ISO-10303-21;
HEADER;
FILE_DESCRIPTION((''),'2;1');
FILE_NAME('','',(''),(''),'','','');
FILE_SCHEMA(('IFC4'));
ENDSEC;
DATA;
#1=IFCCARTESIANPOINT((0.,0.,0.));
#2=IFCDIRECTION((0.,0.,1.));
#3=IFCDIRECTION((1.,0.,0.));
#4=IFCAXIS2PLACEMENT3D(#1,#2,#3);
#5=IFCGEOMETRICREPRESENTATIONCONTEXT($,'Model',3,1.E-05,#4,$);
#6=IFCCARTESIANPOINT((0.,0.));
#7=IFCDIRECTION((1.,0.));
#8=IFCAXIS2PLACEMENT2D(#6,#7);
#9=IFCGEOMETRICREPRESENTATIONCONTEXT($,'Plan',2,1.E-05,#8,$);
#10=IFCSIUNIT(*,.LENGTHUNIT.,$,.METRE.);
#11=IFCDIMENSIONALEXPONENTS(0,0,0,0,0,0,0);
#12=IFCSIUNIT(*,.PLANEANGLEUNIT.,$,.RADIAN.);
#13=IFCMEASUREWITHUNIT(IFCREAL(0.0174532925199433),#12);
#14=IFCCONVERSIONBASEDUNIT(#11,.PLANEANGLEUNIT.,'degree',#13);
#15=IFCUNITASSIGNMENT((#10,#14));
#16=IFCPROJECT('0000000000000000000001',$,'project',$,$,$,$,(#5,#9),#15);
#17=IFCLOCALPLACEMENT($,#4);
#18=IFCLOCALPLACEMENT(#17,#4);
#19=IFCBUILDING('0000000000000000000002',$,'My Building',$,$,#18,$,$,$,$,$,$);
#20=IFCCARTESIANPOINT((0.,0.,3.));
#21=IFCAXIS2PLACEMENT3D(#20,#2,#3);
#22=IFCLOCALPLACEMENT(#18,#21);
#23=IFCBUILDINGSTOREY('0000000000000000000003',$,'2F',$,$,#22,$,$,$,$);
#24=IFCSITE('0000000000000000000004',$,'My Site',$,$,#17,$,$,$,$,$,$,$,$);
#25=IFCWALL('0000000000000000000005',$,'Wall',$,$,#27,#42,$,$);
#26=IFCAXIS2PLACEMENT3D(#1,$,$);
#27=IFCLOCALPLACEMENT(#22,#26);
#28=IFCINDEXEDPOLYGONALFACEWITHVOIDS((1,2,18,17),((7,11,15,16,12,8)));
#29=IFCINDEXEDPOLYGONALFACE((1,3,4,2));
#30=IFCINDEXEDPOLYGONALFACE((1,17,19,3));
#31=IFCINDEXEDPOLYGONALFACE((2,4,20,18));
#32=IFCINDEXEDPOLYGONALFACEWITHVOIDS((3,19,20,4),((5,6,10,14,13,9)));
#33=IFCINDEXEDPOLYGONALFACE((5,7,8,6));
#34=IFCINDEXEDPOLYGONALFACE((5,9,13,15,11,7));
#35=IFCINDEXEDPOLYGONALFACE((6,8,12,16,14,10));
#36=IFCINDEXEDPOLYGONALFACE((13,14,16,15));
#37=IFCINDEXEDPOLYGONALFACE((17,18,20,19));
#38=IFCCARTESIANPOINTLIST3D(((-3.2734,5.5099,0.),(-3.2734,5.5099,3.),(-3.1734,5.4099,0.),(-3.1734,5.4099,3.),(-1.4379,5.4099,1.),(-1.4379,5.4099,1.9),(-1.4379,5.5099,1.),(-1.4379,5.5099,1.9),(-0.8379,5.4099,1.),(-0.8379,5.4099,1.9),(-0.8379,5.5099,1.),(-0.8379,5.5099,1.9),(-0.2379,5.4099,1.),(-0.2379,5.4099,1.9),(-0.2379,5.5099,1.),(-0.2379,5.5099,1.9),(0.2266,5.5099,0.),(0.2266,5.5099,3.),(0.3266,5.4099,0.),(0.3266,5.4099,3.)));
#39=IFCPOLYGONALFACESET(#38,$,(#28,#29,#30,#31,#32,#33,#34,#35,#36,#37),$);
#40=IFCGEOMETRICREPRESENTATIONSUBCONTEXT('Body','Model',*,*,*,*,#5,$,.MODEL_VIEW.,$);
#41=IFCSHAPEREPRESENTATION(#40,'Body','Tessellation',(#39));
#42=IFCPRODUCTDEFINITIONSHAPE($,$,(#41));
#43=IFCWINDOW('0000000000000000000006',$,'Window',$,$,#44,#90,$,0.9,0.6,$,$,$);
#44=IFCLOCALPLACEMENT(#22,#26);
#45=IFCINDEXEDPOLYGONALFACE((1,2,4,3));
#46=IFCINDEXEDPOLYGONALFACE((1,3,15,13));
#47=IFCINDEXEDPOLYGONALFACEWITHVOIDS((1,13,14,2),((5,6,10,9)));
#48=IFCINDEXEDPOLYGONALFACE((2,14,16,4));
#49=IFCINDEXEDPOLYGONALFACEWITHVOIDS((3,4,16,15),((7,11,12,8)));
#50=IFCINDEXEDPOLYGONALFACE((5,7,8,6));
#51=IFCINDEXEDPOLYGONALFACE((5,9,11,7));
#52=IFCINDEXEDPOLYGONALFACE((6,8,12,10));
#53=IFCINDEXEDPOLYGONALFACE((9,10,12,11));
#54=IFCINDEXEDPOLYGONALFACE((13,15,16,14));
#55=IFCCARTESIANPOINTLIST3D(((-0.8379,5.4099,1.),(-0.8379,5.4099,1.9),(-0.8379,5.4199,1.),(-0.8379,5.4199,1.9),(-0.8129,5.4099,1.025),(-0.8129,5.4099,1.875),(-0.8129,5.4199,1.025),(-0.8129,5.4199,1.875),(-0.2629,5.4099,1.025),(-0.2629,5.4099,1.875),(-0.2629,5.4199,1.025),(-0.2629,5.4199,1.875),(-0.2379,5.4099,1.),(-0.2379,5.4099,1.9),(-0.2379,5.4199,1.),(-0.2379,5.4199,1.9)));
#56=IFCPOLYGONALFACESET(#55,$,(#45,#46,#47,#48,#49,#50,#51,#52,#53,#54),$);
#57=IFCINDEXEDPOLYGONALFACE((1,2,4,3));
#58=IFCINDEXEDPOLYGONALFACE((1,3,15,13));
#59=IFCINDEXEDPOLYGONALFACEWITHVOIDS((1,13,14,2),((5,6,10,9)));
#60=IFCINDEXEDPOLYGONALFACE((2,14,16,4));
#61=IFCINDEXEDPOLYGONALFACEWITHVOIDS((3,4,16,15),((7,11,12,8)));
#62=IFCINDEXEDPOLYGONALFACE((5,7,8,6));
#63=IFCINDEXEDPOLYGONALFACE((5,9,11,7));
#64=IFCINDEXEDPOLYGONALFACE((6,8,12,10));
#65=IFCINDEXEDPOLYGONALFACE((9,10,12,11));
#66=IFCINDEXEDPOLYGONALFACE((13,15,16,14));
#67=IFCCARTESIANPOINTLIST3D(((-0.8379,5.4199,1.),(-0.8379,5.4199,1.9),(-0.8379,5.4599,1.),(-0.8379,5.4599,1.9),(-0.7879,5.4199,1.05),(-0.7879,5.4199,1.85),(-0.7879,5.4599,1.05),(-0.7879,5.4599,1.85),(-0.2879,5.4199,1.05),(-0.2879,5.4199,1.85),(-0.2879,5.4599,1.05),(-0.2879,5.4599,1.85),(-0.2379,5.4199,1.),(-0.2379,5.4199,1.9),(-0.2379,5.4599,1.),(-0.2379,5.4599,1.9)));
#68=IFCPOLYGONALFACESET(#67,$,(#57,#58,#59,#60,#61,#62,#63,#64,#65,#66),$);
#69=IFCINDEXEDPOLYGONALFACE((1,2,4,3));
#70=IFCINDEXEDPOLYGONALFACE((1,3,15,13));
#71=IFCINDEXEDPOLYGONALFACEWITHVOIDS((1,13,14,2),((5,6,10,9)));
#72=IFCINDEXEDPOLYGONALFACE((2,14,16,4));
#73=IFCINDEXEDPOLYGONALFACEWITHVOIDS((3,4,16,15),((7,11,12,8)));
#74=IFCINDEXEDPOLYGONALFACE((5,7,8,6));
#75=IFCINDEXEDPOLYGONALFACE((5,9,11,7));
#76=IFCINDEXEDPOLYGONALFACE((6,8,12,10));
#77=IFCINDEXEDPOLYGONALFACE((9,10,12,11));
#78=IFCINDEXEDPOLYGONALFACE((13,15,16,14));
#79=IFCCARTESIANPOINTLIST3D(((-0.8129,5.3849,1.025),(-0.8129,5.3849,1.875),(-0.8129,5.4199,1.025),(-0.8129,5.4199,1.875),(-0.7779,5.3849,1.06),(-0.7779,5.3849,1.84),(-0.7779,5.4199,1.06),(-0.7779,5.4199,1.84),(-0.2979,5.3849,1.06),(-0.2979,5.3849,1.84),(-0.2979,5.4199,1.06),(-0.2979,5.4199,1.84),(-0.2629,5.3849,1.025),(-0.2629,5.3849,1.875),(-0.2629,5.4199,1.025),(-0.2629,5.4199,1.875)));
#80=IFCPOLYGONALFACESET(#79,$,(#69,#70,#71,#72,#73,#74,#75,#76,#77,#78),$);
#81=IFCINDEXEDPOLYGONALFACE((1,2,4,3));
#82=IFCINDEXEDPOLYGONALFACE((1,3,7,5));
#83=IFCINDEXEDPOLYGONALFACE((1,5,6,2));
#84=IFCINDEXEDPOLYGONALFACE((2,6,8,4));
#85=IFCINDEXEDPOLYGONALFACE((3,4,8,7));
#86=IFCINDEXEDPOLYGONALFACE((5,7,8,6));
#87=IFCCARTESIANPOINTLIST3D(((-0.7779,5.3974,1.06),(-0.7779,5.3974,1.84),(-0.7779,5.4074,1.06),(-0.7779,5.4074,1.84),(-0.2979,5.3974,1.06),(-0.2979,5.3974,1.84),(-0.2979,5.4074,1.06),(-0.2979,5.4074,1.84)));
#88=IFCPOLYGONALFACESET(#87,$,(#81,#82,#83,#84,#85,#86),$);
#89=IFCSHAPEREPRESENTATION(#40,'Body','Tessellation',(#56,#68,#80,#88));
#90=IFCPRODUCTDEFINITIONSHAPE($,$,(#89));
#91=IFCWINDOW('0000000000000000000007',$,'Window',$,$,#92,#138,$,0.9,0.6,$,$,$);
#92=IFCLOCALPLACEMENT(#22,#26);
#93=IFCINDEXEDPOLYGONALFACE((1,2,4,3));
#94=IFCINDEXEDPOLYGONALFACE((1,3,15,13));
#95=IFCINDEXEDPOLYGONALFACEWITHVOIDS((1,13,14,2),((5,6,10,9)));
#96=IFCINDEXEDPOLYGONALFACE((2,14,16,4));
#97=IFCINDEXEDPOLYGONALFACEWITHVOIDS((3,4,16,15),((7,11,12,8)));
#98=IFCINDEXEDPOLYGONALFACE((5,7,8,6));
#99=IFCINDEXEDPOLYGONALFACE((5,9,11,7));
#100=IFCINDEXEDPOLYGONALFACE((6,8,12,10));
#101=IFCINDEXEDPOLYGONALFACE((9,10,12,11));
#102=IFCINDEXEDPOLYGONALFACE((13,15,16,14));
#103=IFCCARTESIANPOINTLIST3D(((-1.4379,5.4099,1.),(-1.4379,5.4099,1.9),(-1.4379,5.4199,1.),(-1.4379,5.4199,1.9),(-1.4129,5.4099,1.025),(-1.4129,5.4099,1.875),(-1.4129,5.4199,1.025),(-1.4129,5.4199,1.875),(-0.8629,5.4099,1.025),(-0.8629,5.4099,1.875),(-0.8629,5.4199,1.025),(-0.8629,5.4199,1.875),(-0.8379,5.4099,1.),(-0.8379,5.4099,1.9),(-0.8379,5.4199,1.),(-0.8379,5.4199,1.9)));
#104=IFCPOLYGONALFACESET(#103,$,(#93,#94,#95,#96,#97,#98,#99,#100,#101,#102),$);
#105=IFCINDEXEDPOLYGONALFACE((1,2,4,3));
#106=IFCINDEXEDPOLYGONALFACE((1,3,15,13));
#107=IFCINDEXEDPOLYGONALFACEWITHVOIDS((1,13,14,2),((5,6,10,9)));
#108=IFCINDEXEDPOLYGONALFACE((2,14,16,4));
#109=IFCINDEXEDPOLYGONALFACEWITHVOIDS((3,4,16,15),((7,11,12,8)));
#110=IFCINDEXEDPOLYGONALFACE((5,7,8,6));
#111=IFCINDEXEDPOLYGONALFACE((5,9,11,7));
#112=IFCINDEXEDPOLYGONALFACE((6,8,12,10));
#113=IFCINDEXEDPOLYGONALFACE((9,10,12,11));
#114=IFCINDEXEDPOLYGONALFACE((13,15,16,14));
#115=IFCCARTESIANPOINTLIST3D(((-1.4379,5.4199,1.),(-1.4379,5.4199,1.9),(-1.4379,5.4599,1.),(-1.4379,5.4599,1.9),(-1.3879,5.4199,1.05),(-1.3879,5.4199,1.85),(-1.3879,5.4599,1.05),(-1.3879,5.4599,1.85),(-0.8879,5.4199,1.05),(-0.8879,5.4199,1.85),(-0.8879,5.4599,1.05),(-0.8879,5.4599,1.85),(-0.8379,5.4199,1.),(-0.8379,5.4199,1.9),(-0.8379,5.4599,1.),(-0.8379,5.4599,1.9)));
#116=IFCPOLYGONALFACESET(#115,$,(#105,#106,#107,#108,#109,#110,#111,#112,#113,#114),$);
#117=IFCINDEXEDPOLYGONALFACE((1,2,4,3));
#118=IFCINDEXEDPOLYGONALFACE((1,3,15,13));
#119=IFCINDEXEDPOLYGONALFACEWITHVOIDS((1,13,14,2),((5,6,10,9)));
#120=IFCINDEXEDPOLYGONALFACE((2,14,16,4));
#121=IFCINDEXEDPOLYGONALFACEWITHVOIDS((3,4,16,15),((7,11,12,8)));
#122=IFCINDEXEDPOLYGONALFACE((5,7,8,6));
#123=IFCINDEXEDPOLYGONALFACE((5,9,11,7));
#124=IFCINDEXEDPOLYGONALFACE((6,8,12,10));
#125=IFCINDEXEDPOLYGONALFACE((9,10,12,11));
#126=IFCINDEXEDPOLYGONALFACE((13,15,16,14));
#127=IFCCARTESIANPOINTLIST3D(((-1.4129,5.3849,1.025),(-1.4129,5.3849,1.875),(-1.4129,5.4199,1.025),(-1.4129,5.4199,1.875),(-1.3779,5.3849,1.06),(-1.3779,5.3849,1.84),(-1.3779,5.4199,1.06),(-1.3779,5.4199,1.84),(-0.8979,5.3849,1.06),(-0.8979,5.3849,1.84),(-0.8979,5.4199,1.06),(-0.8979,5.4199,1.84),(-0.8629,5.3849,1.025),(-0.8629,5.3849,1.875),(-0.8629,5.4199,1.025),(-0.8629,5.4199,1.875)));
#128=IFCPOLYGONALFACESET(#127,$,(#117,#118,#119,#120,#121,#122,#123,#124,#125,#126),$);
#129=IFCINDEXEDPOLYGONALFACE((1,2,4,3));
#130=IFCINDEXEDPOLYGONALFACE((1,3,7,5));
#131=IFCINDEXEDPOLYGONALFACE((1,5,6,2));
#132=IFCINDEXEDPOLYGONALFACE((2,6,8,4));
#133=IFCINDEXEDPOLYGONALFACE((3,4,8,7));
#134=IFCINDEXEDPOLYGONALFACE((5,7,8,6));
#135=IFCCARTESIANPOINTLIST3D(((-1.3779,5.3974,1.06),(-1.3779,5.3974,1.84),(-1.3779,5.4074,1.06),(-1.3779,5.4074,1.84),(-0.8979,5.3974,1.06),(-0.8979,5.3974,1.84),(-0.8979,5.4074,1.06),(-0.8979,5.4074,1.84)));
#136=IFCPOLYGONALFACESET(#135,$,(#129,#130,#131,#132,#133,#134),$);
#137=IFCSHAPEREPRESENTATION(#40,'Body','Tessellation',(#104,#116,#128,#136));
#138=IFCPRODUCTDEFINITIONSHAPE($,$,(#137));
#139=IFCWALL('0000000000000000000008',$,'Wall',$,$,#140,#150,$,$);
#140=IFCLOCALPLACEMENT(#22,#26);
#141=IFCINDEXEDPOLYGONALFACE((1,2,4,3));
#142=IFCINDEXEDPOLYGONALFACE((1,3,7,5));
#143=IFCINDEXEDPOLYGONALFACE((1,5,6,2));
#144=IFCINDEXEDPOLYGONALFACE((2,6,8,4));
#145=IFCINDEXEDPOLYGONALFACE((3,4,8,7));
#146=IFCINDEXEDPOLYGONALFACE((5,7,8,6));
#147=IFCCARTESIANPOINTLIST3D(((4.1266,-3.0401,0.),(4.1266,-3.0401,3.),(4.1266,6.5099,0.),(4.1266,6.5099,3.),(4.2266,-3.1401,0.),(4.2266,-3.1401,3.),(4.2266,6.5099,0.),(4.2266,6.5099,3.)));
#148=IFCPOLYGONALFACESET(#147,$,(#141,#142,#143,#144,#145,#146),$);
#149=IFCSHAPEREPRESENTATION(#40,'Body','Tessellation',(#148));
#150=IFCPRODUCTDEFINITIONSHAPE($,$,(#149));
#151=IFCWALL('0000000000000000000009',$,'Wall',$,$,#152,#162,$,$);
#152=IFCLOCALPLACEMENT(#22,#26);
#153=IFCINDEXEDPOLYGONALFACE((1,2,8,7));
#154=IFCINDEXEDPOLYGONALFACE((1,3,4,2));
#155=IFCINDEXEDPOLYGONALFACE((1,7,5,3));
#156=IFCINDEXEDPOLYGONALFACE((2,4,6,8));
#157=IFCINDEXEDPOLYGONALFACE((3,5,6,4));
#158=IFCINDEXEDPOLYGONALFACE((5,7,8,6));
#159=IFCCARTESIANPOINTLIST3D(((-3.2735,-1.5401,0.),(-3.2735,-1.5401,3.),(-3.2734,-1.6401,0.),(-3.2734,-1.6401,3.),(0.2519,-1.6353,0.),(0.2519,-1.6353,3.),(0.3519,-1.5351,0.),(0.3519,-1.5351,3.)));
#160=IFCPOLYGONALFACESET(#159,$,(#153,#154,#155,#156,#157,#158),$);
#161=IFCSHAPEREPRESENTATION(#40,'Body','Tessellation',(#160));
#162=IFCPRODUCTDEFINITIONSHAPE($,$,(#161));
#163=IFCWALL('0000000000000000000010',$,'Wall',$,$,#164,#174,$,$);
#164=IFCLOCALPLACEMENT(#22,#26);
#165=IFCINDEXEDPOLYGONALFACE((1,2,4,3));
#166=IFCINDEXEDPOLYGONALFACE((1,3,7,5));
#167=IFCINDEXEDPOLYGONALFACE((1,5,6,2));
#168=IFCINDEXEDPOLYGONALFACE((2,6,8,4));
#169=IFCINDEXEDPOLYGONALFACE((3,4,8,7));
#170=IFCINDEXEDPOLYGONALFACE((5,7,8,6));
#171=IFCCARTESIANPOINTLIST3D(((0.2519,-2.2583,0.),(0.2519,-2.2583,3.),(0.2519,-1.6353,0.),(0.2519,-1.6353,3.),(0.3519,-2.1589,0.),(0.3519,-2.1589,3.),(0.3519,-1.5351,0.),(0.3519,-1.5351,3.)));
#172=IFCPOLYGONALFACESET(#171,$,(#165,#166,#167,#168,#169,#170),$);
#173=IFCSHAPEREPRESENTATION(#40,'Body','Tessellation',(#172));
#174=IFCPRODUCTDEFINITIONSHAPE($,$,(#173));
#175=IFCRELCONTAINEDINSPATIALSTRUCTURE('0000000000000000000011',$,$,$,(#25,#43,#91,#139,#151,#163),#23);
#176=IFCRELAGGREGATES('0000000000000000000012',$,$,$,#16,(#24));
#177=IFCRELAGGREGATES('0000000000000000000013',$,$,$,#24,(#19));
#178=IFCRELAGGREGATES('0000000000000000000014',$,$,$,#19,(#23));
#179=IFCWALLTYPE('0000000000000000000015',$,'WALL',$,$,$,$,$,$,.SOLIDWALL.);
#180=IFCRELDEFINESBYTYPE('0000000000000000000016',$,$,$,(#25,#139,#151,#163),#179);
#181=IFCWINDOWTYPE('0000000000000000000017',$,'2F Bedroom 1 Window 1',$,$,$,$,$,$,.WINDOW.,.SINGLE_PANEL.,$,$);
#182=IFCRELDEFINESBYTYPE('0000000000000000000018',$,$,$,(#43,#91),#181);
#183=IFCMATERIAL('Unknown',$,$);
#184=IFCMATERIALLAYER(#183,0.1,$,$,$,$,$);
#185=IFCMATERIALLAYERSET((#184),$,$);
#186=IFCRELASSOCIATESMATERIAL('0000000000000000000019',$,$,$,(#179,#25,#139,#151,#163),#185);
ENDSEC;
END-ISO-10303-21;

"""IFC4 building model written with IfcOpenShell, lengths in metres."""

from ifc_helpers import new_model, entity, si_unit, converted_unit, frame, origin_with_axes, origin_2d_with_axis, place, context, subcontext, project, spatial, line, indexed_curve, outline, extrude, shape, source, transform, mapped, material, layer, layer_set, layer_usage, type_object, type_shapes, element, fill, save


model = new_model("IFC4")

# Units and contexts
model_context = context("Model", 3, precision=1e-05, world=origin_with_axes())
plan_context = context("Plan", 2, precision=1e-05, world=origin_2d_with_axis())
body_context_1 = subcontext(model_context, "Body", "Model", "MODEL_VIEW")
body_context_2 = subcontext(plan_context, "Body", "Plan", "PLAN_VIEW")
ifc_project = project(units=[si_unit("LENGTHUNIT", "METRE"), converted_unit("PLANEANGLEUNIT", "degree", entity("IfcReal", 0.0174532925199433), si_unit("PLANEANGLEUNIT", "RADIAN"), dimensions=[0, 0, 0, 0, 0, 0, 0])], contexts=[model_context, plan_context])

# Site, building, storey
site_placement = place(None, origin_with_axes())
site = spatial("IfcSite", under=ifc_project, at=site_placement, Name="My Site")
building_placement = place(site_placement, origin_with_axes())
building = spatial("IfcBuilding", under=site, at=building_placement, Name="My Building")
storey_placement = place(building_placement, frame((0.0, 0.0, 3.0), z_axis=(0.0, 0.0, 1.0), x_axis=(1.0, 0.0, 0.0)))
storey = spatial("IfcBuildingStorey", under=building, at=storey_placement, Name="2F")

# Shared definitions
ifc_material = material(Name="Unknown")

# Shared definitions
ifc_layer_1 = layer(ifc_material, 0.1)
ifc_layer_set_1 = layer_set([ifc_layer_1])
wall_type = type_object("IfcWallType", Name="WALL", PredefinedType="SOLIDWALL", material=ifc_layer_set_1)

# Wall, openings, windows
ifc_layer_usage_1 = layer_usage(ifc_layer_set_1, "AXIS2", "POSITIVE", 0.0)
wall_1_placement = place(storey_placement, frame((0.2266, 5.5099, 0.0), z_axis=(0.0, 0.0, 1.0), x_axis=(-1.0, 0.0, 0.0)))
wall_1 = element("IfcWall", 1, at=wall_1_placement, inside=storey, type_object=wall_type, material=ifc_layer_usage_1, Name="Wall", context=body_context_1, shape_type="SweptSolid", body=[
    extrude(outline(indexed_curve([(0.0, 0.0), (-0.1, 0.1), (3.4, 0.1), (3.5, 0.0)], segments=[line(1, 2, 3, 4, 1)])), origin_with_axes(), (0.0, 0.0, 1.0), 3.0),
])
shared_shape_1 = source(origin_with_axes(), body_context_1, "Body", "SweptSolid", [
    extrude(outline(indexed_curve([(0.0, 0.0), (0.6, 0.0), (0.6, 0.9), (0.0, 0.9)], segments=[line(1, 2, 3, 4, 1)])), frame((0.0, -0.6, 0.0), z_axis=(0.0, -1.0, 0.0), x_axis=(1.0, 0.0, 0.0)), (0.0, 0.0, -1.0), 1.2),
])
opening_1_placement = place(wall_1_placement, frame((0.4645, 0.0, 1.0), z_axis=(0.0, 0.0, 1.0), x_axis=(1.0, 0.0, 0.0)))
opening_1 = element("IfcOpeningElement", 2, at=opening_1_placement, cuts=wall_1, PredefinedType="OPENING", context=body_context_1, shape_type="MappedRepresentation", body=[
    mapped(shared_shape_1, transform((0.0, 0.0, 0.0), x_axis=(1.0, 0.0, 0.0), y_axis=(0.0, 1.0, 0.0), z_axis=(0.0, 0.0, 1.0), scale=1.0)),
])
opening_2_placement = place(wall_1_placement, frame((1.0645, 0.0, 1.0), z_axis=(0.0, 0.0, 1.0), x_axis=(1.0, 0.0, 0.0)))
opening_2 = element("IfcOpeningElement", 3, at=opening_2_placement, cuts=wall_1, PredefinedType="OPENING", context=body_context_1, shape_type="MappedRepresentation", body=[
    mapped(shared_shape_1, transform((0.0, 0.0, 0.0), x_axis=(1.0, 0.0, 0.0), y_axis=(0.0, 1.0, 0.0), z_axis=(0.0, 0.0, 1.0), scale=1.0)),
])
window_type_1 = type_object("IfcWindowType", Name="2F Bedroom 1 Window 1", PartitioningType="SINGLE_PANEL", PredefinedType="WINDOW")
shared_shape_2 = source(origin_with_axes(), body_context_1, "Body", "SweptSolid", [
    extrude(outline(indexed_curve([(0.0, 0.0), (0.6, 0.0), (0.6, 0.9), (0.0, 0.9)], segments=[line(1, 2, 3, 4, 1)]), holes=[indexed_curve([(0.025, 0.025), (0.575, 0.025), (0.575, 0.875), (0.025, 0.875)], segments=[line(1, 2, 3, 4, 1)])]), frame((0.0, 0.09, 0.0), z_axis=(0.0, -1.0, 0.0), x_axis=(1.0, 0.0, 0.0)), (0.0, 0.0, -1.0), 0.01),
    extrude(outline(indexed_curve([(0.0, 0.0), (0.6, 0.0), (0.6, 0.9), (0.0, 0.9)], segments=[line(1, 2, 3, 4, 1)]), holes=[indexed_curve([(0.05, 0.05), (0.55, 0.05), (0.55, 0.85), (0.05, 0.85)], segments=[line(1, 2, 3, 4, 1)])]), frame((0.0, 0.05, 0.0), z_axis=(0.0, -1.0, 0.0), x_axis=(1.0, 0.0, 0.0)), (0.0, 0.0, -1.0), 0.04),
    extrude(outline(indexed_curve([(0.0, 0.0), (0.55, 0.0), (0.55, 0.85), (0.0, 0.85)], segments=[line(1, 2, 3, 4, 1)]), holes=[indexed_curve([(0.035, 0.035), (0.515, 0.035), (0.515, 0.815), (0.035, 0.815)], segments=[line(1, 2, 3, 4, 1)])]), frame((0.025, 0.09, 0.025), z_axis=(0.0, -1.0, 0.0), x_axis=(1.0, 0.0, 0.0)), (0.0, 0.0, -1.0), 0.035),
    extrude(outline(indexed_curve([(0.035, 0.035), (0.515, 0.035), (0.515, 0.815), (0.035, 0.815)], segments=[line(1, 2, 3, 4, 1)])), frame((0.025, 0.1025, 0.025), z_axis=(0.0, -1.0, 0.0), x_axis=(1.0, 0.0, 0.0)), (0.0, 0.0, -1.0), 0.01),
])
shared_shape_3 = source(origin_with_axes(), body_context_2, "Body", "Curve2D", [
    entity("IfcIndexedPolyCurve", entity("IfcCartesianPointList2D", [[0.05, 0.05], [0.55, 0.05]])),
    entity("IfcIndexedPolyCurve", entity("IfcCartesianPointList2D", [[0.0, 0.1], [0.025, 0.1], [0.025, 0.09], [0.05, 0.09], [0.05, 0.05], [0.0, 0.05]]), [entity("IfcLineIndex", [1, 2, 3, 4, 5, 6, 1])]),
    entity("IfcIndexedPolyCurve", entity("IfcCartesianPointList2D", [[0.6, 0.1], [0.575, 0.1], [0.575, 0.09], [0.55, 0.09], [0.55, 0.05], [0.6, 0.05]]), [entity("IfcLineIndex", [1, 2, 3, 4, 5, 6, 1])]),
    entity("IfcIndexedPolyCurve", entity("IfcCartesianPointList2D", [[0.025, 0.09], [0.06, 0.09], [0.06, 0.125], [0.025, 0.125]]), [entity("IfcLineIndex", [1, 2, 3, 4, 1])]),
    entity("IfcIndexedPolyCurve", entity("IfcCartesianPointList2D", [[0.575, 0.09], [0.54, 0.09], [0.54, 0.125], [0.575, 0.125]]), [entity("IfcLineIndex", [1, 2, 3, 4, 1])]),
    entity("IfcIndexedPolyCurve", entity("IfcCartesianPointList2D", [[0.06, 0.09], [0.54, 0.09]])),
    entity("IfcIndexedPolyCurve", entity("IfcCartesianPointList2D", [[0.06, 0.125], [0.54, 0.125]])),
    entity("IfcIndexedPolyCurve", entity("IfcCartesianPointList2D", [[0.06, 0.1075], [0.54, 0.1075]])),
])
type_shapes(window_type_1, [shared_shape_2, shared_shape_3])
window_1_placement = place(opening_1_placement, frame((0.0, 0.0, 0.0), z_axis=(0.0, 0.0, 1.0), x_axis=(1.0, 0.0, 0.0)))
window_1 = element("IfcWindow", 4, at=window_1_placement, inside=storey, type_object=window_type_1, Name="Window", OverallHeight=0.9, OverallWidth=0.6, shapes=[
    shape(body_context_1, "Body", "MappedRepresentation", [mapped(shared_shape_2, transform((0.0, 0.0, 0.0), x_axis=(1.0, 0.0, 0.0), y_axis=(0.0, 1.0, 0.0), z_axis=(0.0, 0.0, 1.0), scale=1.0))]),
    shape(body_context_2, "Body", "MappedRepresentation", [mapped(shared_shape_3, transform((0.0, 0.0, 0.0), x_axis=(1.0, 0.0, 0.0), y_axis=(0.0, 1.0, 0.0), z_axis=(0.0, 0.0, 1.0), scale=1.0))]),
])
fill(opening_1, window_1)
window_2_placement = place(opening_2_placement, frame((0.0, 0.0, 0.0), z_axis=(0.0, 0.0, 1.0), x_axis=(1.0, 0.0, 0.0)))
window_2 = element("IfcWindow", 5, at=window_2_placement, inside=storey, type_object=window_type_1, Name="Window", OverallHeight=0.9, OverallWidth=0.6, shapes=[
    shape(body_context_1, "Body", "MappedRepresentation", [mapped(shared_shape_2, transform((0.0, 0.0, 0.0), x_axis=(1.0, 0.0, 0.0), y_axis=(0.0, 1.0, 0.0), z_axis=(0.0, 0.0, 1.0), scale=1.0))]),
    shape(body_context_2, "Body", "MappedRepresentation", [mapped(shared_shape_3, transform((0.0, 0.0, 0.0), x_axis=(1.0, 0.0, 0.0), y_axis=(0.0, 1.0, 0.0), z_axis=(0.0, 0.0, 1.0), scale=1.0))]),
])
fill(opening_2, window_2)

# Walls
ifc_layer_usage_2 = layer_usage(ifc_layer_set_1, "AXIS2", "POSITIVE", 0.0)
wall_2_placement = place(storey_placement, frame((4.2266, -3.1401, 0.0), z_axis=(0.0, 0.0, 1.0), x_axis=(0.0, 1.0, 0.0)))
element("IfcWall", 6, at=wall_2_placement, inside=storey, type_object=wall_type, material=ifc_layer_usage_2, Name="Wall", context=body_context_1, shape_type="SweptSolid", body=[
    extrude(outline(indexed_curve([(0.0, 0.0), (0.1, 0.1), (9.65, 0.1), (9.65, 0.0)], segments=[line(1, 2, 3, 4, 1)])), origin_with_axes(), (0.0, 0.0, 1.0), 3.0),
])
ifc_layer_usage_3 = layer_usage(ifc_layer_set_1, "AXIS2", "POSITIVE", 0.0)
wall_3_placement = place(storey_placement, frame((-3.2734, -1.6401, 0.0), z_axis=(0.0, 0.0, 1.0), x_axis=(0.999999, 0.001371, 0.0)))
element("IfcWall", 7, at=wall_3_placement, inside=storey, type_object=wall_type, material=ifc_layer_usage_3, Name="Wall", context=body_context_1, shape_type="SweptSolid", body=[
    extrude(outline(indexed_curve([(0.0, 0.0), (0.0, 0.1), (3.6254, 0.1), (3.5253, 0.0)], segments=[line(1, 2, 3, 4, 1)])), origin_with_axes(), (0.0, 0.0, 1.0), 3.0),
])
ifc_layer_usage_4 = layer_usage(ifc_layer_set_1, "AXIS2", "POSITIVE", 0.0)
wall_4_placement = place(storey_placement, frame((0.2519, -1.6353, 0.0), z_axis=(0.0, 0.0, 1.0), x_axis=(0.0, -1.0, 0.0)))
element("IfcWall", 8, at=wall_4_placement, inside=storey, type_object=wall_type, material=ifc_layer_usage_4, Name="Wall", context=body_context_1, shape_type="SweptSolid", body=[
    extrude(outline(indexed_curve([(0.0, 0.0), (-0.1001, 0.1), (0.5237, 0.1), (0.623, 0.0)], segments=[line(1, 2, 3, 4, 1)])), origin_with_axes(), (0.0, 0.0, 1.0), 3.0),
])

save(model, "model.ifc")
